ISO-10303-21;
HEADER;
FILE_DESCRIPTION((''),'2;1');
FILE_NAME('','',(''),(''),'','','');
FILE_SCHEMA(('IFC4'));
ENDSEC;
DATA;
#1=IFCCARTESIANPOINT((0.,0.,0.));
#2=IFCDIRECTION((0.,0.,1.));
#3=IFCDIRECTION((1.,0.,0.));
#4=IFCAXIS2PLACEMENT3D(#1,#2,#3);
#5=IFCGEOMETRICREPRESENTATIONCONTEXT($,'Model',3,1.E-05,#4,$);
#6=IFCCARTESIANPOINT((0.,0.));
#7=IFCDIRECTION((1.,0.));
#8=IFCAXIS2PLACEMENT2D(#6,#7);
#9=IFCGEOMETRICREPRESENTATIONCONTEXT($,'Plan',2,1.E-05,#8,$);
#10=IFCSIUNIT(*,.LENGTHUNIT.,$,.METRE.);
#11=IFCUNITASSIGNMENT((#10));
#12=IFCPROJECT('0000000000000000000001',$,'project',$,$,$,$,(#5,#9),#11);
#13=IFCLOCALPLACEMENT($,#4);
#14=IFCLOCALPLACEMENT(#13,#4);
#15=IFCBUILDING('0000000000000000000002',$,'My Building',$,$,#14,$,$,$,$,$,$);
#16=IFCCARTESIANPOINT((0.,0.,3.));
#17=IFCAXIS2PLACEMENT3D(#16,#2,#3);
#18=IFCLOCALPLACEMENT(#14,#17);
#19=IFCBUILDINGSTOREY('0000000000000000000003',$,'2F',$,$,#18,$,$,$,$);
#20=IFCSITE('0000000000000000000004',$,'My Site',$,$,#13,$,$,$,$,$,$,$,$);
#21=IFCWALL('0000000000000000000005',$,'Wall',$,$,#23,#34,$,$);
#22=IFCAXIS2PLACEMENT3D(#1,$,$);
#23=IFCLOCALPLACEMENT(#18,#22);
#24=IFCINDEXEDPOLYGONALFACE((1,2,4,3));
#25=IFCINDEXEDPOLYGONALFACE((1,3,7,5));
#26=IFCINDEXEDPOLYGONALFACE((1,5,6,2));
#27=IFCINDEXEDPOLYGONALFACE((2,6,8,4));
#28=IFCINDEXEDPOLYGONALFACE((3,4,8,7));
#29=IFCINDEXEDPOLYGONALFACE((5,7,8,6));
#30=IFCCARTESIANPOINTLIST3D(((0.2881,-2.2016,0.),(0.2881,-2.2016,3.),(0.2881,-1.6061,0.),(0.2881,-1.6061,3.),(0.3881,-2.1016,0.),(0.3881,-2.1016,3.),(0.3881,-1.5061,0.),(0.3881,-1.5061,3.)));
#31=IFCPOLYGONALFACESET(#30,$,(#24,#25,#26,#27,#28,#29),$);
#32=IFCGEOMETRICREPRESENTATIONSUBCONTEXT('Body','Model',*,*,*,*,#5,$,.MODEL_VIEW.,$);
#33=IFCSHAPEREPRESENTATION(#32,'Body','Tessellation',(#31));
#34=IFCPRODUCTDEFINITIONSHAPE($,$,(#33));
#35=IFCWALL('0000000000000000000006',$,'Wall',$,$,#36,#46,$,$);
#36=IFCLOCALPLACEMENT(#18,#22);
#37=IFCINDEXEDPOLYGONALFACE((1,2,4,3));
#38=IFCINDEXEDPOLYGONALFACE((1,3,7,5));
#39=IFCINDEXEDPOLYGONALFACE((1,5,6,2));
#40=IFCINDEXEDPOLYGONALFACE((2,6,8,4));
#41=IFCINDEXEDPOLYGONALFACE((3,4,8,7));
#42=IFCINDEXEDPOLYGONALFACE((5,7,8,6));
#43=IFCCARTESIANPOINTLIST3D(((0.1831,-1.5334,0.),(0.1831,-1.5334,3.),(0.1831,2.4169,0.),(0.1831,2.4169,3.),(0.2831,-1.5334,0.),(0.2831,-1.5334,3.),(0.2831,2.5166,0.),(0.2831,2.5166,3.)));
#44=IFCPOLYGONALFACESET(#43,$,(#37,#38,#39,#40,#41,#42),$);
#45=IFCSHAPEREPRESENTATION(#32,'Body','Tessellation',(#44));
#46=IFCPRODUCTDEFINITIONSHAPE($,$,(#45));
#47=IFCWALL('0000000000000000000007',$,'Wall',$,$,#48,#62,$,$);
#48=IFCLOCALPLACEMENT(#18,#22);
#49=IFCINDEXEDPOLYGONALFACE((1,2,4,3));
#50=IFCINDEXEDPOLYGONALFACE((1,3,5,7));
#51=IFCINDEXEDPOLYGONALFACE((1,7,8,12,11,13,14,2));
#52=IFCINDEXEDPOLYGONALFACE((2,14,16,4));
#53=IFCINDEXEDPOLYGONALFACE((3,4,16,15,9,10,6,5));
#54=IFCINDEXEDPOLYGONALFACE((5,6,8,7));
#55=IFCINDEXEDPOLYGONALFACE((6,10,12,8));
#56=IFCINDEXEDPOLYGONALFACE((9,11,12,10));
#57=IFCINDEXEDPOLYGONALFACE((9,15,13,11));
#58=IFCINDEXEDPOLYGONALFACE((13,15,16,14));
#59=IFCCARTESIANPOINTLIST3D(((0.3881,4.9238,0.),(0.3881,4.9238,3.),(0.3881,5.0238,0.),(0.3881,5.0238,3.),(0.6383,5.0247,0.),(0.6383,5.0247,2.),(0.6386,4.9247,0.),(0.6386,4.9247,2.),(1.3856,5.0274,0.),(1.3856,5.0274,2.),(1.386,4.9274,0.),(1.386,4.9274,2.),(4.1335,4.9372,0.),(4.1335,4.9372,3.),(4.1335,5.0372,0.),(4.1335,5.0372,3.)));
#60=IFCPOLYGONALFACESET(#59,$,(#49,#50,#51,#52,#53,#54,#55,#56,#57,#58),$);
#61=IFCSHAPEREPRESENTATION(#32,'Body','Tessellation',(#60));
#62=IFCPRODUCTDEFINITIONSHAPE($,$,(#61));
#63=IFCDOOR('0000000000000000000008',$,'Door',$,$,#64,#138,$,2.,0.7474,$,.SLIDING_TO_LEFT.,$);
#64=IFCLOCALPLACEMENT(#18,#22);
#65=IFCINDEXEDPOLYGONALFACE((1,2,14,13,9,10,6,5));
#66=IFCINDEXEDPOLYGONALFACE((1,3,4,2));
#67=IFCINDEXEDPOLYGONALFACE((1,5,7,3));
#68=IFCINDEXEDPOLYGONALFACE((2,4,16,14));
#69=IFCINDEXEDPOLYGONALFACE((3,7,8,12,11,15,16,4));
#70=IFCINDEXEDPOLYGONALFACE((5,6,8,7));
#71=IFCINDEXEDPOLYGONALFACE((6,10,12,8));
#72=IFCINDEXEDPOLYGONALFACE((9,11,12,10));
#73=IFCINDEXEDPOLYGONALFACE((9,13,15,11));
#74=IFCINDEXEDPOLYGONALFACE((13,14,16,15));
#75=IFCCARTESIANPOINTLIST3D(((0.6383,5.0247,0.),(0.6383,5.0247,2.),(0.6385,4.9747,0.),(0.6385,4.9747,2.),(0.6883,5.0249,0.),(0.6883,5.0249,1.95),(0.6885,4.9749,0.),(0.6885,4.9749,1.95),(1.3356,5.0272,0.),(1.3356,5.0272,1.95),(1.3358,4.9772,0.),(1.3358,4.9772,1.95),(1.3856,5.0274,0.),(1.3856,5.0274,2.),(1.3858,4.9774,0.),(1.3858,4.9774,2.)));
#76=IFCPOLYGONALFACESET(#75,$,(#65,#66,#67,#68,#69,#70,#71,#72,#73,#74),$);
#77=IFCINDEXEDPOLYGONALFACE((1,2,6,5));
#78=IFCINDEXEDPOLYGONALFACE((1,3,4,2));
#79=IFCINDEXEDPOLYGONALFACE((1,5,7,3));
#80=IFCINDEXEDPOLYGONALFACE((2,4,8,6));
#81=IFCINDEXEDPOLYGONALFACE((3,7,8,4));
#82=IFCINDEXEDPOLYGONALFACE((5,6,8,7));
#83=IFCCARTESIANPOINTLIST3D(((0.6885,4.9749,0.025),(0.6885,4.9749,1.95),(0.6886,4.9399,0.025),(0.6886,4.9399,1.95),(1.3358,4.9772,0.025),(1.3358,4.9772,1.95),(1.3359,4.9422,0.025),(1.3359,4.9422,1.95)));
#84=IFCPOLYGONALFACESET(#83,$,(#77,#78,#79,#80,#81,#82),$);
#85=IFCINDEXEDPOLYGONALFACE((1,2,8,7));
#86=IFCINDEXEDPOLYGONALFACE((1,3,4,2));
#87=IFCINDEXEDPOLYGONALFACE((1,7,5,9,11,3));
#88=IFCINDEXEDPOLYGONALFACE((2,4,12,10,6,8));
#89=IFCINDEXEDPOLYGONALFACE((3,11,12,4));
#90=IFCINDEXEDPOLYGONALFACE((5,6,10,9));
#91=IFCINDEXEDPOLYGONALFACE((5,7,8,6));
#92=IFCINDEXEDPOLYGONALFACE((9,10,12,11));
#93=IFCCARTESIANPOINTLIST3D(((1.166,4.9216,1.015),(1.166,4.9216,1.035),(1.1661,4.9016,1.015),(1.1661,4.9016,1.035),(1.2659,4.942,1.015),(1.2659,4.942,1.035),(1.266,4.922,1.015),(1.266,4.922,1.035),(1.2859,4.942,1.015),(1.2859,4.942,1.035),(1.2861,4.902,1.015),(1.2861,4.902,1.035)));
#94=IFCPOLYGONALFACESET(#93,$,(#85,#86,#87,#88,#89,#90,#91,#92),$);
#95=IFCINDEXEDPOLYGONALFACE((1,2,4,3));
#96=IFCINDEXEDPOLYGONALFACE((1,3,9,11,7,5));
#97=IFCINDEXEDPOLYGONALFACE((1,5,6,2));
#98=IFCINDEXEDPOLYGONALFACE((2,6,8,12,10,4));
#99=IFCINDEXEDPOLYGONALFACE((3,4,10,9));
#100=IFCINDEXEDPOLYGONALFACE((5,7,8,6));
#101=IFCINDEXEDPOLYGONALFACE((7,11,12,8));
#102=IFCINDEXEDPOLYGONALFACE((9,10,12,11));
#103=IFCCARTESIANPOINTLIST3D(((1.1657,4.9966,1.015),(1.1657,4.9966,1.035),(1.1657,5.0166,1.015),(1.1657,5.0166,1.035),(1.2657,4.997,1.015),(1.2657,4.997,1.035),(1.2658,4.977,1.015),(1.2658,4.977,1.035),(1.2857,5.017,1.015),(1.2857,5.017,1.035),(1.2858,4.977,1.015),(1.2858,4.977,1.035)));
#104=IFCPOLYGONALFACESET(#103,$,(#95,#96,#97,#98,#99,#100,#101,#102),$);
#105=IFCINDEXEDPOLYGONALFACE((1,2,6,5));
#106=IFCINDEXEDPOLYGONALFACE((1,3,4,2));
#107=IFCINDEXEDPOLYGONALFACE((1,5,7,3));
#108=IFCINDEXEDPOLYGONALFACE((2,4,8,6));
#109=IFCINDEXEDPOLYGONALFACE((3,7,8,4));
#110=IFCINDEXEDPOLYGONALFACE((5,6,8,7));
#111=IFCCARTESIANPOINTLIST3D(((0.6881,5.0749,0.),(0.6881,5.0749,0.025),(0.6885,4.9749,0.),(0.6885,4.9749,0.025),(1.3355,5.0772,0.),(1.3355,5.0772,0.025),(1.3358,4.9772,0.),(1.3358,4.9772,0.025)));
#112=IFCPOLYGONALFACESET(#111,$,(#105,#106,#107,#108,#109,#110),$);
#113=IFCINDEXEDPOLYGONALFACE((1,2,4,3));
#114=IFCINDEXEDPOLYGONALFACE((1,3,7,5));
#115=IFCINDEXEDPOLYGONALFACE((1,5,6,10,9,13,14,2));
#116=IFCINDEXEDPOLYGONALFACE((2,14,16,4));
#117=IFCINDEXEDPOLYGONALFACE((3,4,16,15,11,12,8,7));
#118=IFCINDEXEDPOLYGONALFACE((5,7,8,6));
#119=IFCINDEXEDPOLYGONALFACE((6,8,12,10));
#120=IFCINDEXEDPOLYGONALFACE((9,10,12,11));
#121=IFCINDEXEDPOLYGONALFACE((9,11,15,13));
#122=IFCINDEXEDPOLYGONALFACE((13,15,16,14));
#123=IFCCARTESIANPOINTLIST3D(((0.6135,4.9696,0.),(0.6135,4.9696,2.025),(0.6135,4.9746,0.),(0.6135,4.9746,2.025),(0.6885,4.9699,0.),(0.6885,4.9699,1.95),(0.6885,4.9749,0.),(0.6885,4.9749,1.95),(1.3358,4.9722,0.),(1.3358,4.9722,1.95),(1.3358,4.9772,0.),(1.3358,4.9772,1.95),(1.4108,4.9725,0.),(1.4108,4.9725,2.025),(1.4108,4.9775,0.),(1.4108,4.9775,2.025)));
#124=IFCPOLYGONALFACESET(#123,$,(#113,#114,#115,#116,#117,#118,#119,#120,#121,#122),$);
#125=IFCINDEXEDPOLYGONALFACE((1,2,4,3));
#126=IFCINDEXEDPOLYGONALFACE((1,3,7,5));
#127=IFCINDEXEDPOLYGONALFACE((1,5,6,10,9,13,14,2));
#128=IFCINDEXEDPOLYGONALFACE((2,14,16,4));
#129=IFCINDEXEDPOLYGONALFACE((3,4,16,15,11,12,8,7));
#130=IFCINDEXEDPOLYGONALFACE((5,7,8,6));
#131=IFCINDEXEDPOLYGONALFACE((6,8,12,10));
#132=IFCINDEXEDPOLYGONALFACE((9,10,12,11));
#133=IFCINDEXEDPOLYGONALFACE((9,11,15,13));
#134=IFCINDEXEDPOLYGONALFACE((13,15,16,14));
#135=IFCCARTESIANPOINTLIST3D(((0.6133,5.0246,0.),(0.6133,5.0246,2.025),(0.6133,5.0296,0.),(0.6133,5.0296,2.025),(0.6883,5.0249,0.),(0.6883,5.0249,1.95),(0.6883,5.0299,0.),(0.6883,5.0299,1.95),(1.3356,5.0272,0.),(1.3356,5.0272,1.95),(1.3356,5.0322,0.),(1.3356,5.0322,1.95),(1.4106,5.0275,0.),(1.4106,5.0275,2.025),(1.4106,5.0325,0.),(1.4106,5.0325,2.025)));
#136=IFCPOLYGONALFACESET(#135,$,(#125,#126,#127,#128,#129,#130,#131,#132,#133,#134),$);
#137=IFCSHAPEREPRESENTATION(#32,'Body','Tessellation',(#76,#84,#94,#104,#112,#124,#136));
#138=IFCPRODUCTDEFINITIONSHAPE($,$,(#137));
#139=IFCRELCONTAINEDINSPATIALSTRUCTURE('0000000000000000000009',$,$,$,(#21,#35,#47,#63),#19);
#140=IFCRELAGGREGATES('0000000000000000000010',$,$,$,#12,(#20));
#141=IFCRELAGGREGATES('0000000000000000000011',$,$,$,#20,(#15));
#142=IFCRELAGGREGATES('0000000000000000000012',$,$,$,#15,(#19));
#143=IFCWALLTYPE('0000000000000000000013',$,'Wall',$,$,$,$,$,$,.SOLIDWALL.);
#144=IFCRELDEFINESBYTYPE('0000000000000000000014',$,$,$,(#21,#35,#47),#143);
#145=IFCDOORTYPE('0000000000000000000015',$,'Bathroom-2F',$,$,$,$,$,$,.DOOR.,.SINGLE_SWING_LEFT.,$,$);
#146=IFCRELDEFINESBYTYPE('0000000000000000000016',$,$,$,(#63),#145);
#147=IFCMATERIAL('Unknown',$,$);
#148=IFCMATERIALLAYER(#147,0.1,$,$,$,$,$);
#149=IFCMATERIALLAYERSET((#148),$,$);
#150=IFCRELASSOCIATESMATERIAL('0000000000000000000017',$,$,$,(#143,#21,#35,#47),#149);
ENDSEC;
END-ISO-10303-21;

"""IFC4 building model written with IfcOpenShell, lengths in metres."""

from ifc_helpers import new_model, entity, si_unit, frame, origin_with_axes, origin_2d_with_axis, place, context, subcontext, project, spatial, line, indexed_curve, outline, extrude, shape, source, transform, mapped, material, layer, layer_set, layer_usage, type_object, type_shapes, element, fill, save


model = new_model("IFC4")

# Units and contexts
model_context = context("Model", 3, precision=1e-05, world=origin_with_axes())
plan_context = context("Plan", 2, precision=1e-05, world=origin_2d_with_axis())
body_context_1 = subcontext(model_context, "Body", "Model", "MODEL_VIEW")
body_context_2 = subcontext(plan_context, "Body", "Plan", "PLAN_VIEW")
ifc_project = project(units=[si_unit("LENGTHUNIT", "METRE")], contexts=[model_context, plan_context])

# Site, building, storey
site_placement = place(None, origin_with_axes())
site = spatial("IfcSite", under=ifc_project, at=site_placement, Name="My Site")
building_placement = place(site_placement, origin_with_axes())
building = spatial("IfcBuilding", under=site, at=building_placement, Name="My Building")
storey_placement = place(building_placement, frame((0.0, 0.0, 3.0), z_axis=(0.0, 0.0, 1.0), x_axis=(1.0, 0.0, 0.0)))
storey = spatial("IfcBuildingStorey", under=building, at=storey_placement, Name="2F")

# Shared definitions
ifc_material = material(Name="Unknown")
ifc_layer = layer(ifc_material, 0.1)
ifc_layer_set = layer_set([ifc_layer])
wall_type = type_object("IfcWallType", Name="Wall", PredefinedType="SOLIDWALL", material=ifc_layer_set)

# Walls
ifc_layer_usage_1 = layer_usage(ifc_layer_set, "AXIS2", "POSITIVE", 0.0)
wall_1_placement = place(storey_placement, frame((0.2881, -1.6061, 0.0), z_axis=(0.0, 0.0, 1.0), x_axis=(0.0, -1.0, 0.0)))
element("IfcWall", 1, at=wall_1_placement, inside=storey, type_object=wall_type, material=ifc_layer_usage_1, Name="Wall", context=body_context_1, shape_type="SweptSolid", body=[
    extrude(outline(indexed_curve([(0.0, 0.0), (-0.1, 0.1), (0.4955, 0.1), (0.5955, 0.0)], segments=[line(1, 2, 3, 4, 1)])), origin_with_axes(), (0.0, 0.0, 1.0), 3.0),
])
ifc_layer_usage_2 = layer_usage(ifc_layer_set, "AXIS2", "POSITIVE", 0.0)
wall_2_placement = place(storey_placement, frame((0.2831, -1.5334, 0.0), z_axis=(0.0, 0.0, 1.0), x_axis=(0.0, 1.0, 0.0)))
element("IfcWall", 2, at=wall_2_placement, inside=storey, type_object=wall_type, material=ifc_layer_usage_2, Name="Wall", context=body_context_1, shape_type="SweptSolid", body=[
    extrude(outline(indexed_curve([(0.0, 0.0), (0.0, 0.1), (3.9504, 0.1), (4.05, 0.0)], segments=[line(1, 2, 3, 4, 1)])), origin_with_axes(), (0.0, 0.0, 1.0), 3.0),
])

# Wall, opening, door
ifc_layer_usage_3 = layer_usage(ifc_layer_set, "AXIS2", "POSITIVE", 0.0)
wall_3_placement = place(storey_placement, frame((0.3881, 4.9238, 0.0), z_axis=(0.0, 0.0, 1.0), x_axis=(0.999994, 0.003582, 0.0)))
wall_3 = element("IfcWall", 3, at=wall_3_placement, inside=storey, type_object=wall_type, material=ifc_layer_usage_3, Name="Wall", context=body_context_1, shape_type="SweptSolid", body=[
    extrude(outline(indexed_curve([(0.0, 0.0), (0.0004, 0.1), (3.7458, 0.1), (3.7454, 0.0)], segments=[line(1, 2, 3, 4, 1)])), origin_with_axes(), (0.0, 0.0, 1.0), 3.0),
])
shared_shape_1 = source(origin_with_axes(), body_context_1, "Body", "SweptSolid", [
    extrude(outline(indexed_curve([(0.0, 0.0), (0.7474, 0.0), (0.7474, 2.0), (0.0, 2.0)], segments=[line(1, 2, 3, 4, 1)])), frame((0.0, -0.6, 0.0), z_axis=(0.0, -1.0, 0.0), x_axis=(1.0, 0.0, 0.0)), (0.0, 0.0, -1.0), 1.2),
])
opening_1_placement = place(wall_3_placement, frame((0.2505, 0.05, 0.0), z_axis=(0.0, 0.0, 1.0), x_axis=(1.0, -0.000001, 0.0)))
opening_1 = element("IfcOpeningElement", 4, at=opening_1_placement, cuts=wall_3, PredefinedType="OPENING", context=body_context_1, shape_type="MappedRepresentation", body=[
    mapped(shared_shape_1, transform((0.0, 0.0, 0.0), x_axis=(1.0, 0.0, 0.0), y_axis=(0.0, 1.0, 0.0), z_axis=(0.0, 0.0, 1.0), scale=1.0)),
])
door_type_1 = type_object("IfcDoorType", Name="Bathroom-2F", OperationType="SINGLE_SWING_LEFT", PredefinedType="DOOR")
shared_shape_2 = source(origin_with_axes(), body_context_1, "Body", "SweptSolid", [
    extrude(outline(indexed_curve([(0.0, 0.0), (0.0, 2.0), (0.7474, 2.0), (0.7474, 0.0), (0.6974, 0.0), (0.6974, 1.95), (0.05, 1.95), (0.05, 0.0)], segments=[line(1, 2, 3, 4, 5, 6, 7, 8, 1)])), frame((0.0, 0.0, 0.0), z_axis=(0.0, -1.0, 0.0), x_axis=(1.0, 0.0, 0.0)), (0.0, 0.0, -1.0), 0.05),
    extrude(outline(indexed_curve([(0.0, 0.0), (0.6474, 0.0), (0.6474, 0.035), (0.0, 0.035)], segments=[line(1, 2, 3, 4, 1)])), frame((0.05, -0.035, 0.025), z_axis=(0.0, 0.0, 1.0), x_axis=(1.0, 0.0, 0.0)), (0.0, 0.0, 1.0), 1.925),
    extrude(outline(indexed_curve([(0.0, 0.0), (0.0, -0.04), (-0.12, -0.04), (-0.12, -0.02), (-0.02, -0.02), (-0.02, 0.0)], segments=[line(1, 2, 3, 4, 5, 6, 1)])), frame((0.6474, -0.035, 1.015), z_axis=(0.0, 0.0, 1.0), x_axis=(1.0, 0.0, 0.0)), (0.0, 0.0, 1.0), 0.02),
    extrude(outline(indexed_curve([(0.0, 0.0), (0.0, 0.04), (-0.12, 0.04), (-0.12, 0.02), (-0.02, 0.02), (-0.02, 0.0)], segments=[line(1, 2, 3, 4, 5, 6, 1)])), frame((0.6474, 0.0, 1.015), z_axis=(0.0, 0.0, 1.0), x_axis=(1.0, 0.0, 0.0)), (0.0, 0.0, 1.0), 0.02),
    extrude(outline(indexed_curve([(0.0, 0.0), (0.6474, 0.0), (0.6474, 0.1), (0.0, 0.1)], segments=[line(1, 2, 3, 4, 1)])), frame((0.05, 0.0, 0.0), z_axis=(0.0, 0.0, 1.0), x_axis=(1.0, 0.0, 0.0)), (0.0, 0.0, 1.0), 0.025),
    extrude(outline(indexed_curve([(0.0, 0.0), (0.0, 2.025), (0.7974, 2.025), (0.7974, 0.0), (0.7224, 0.0), (0.7224, 1.95), (0.075, 1.95), (0.075, 0.0)], segments=[line(1, 2, 3, 4, 5, 6, 7, 8, 1)])), frame((-0.025, -0.005, 0.0), z_axis=(0.0, -1.0, 0.0), x_axis=(1.0, 0.0, 0.0)), (0.0, 0.0, -1.0), 0.005),
    extrude(outline(indexed_curve([(0.0, 0.0), (0.0, 2.025), (0.7974, 2.025), (0.7974, 0.0), (0.7224, 0.0), (0.7224, 1.95), (0.075, 1.95), (0.075, 0.0)], segments=[line(1, 2, 3, 4, 5, 6, 7, 8, 1)])), frame((-0.025, 0.05, 0.0), z_axis=(0.0, -1.0, 0.0), x_axis=(1.0, 0.0, 0.0)), (0.0, 0.0, -1.0), 0.005),
])
shared_shape_3 = source(origin_with_axes(), body_context_2, "Body", "Curve2D", [
    entity("IfcIndexedPolyCurve", entity("IfcCartesianPointList2D", [[0.0, 0.0], [0.05, 0.0], [0.05, 0.05], [0.0, 0.05]]), [entity("IfcLineIndex", [1, 2, 3, 4, 1])]),
    entity("IfcIndexedPolyCurve", entity("IfcCartesianPointList2D", [[0.7474, 0.0], [0.6974, 0.0], [0.6974, 0.05], [0.7474, 0.05]]), [entity("IfcLineIndex", [1, 2, 3, 4, 1])]),
    entity("IfcIndexedPolyCurve", entity("IfcCartesianPointList2D", [[-0.2737, -0.035], [0.3737, -0.035], [0.3737, 0.0], [-0.2737, 0.0]]), [entity("IfcLineIndex", [1, 2, 3, 4, 1])]),
])
type_shapes(door_type_1, [shared_shape_2, shared_shape_3])
door_1_placement = place(opening_1_placement, frame((0.0, 0.0, 0.0), z_axis=(0.0, 0.0, 1.0), x_axis=(1.0, 0.0, 0.0)))
door_1 = element("IfcDoor", 5, at=door_1_placement, inside=storey, type_object=door_type_1, Name="Door", OperationType="SLIDING_TO_LEFT", OverallHeight=2.0, OverallWidth=0.7474, shapes=[
    shape(body_context_1, "Body", "MappedRepresentation", [mapped(shared_shape_2, transform((0.0, 0.0, 0.0), x_axis=(1.0, 0.0, 0.0), y_axis=(0.0, 1.0, 0.0), z_axis=(0.0, 0.0, 1.0), scale=1.0))]),
    shape(body_context_2, "Body", "MappedRepresentation", [mapped(shared_shape_3, transform((0.0, 0.0, 0.0), x_axis=(1.0, 0.0, 0.0), y_axis=(0.0, 1.0, 0.0), z_axis=(0.0, 0.0, 1.0), scale=1.0))]),
])
fill(opening_1, door_1)

save(model, "model.ifc")
